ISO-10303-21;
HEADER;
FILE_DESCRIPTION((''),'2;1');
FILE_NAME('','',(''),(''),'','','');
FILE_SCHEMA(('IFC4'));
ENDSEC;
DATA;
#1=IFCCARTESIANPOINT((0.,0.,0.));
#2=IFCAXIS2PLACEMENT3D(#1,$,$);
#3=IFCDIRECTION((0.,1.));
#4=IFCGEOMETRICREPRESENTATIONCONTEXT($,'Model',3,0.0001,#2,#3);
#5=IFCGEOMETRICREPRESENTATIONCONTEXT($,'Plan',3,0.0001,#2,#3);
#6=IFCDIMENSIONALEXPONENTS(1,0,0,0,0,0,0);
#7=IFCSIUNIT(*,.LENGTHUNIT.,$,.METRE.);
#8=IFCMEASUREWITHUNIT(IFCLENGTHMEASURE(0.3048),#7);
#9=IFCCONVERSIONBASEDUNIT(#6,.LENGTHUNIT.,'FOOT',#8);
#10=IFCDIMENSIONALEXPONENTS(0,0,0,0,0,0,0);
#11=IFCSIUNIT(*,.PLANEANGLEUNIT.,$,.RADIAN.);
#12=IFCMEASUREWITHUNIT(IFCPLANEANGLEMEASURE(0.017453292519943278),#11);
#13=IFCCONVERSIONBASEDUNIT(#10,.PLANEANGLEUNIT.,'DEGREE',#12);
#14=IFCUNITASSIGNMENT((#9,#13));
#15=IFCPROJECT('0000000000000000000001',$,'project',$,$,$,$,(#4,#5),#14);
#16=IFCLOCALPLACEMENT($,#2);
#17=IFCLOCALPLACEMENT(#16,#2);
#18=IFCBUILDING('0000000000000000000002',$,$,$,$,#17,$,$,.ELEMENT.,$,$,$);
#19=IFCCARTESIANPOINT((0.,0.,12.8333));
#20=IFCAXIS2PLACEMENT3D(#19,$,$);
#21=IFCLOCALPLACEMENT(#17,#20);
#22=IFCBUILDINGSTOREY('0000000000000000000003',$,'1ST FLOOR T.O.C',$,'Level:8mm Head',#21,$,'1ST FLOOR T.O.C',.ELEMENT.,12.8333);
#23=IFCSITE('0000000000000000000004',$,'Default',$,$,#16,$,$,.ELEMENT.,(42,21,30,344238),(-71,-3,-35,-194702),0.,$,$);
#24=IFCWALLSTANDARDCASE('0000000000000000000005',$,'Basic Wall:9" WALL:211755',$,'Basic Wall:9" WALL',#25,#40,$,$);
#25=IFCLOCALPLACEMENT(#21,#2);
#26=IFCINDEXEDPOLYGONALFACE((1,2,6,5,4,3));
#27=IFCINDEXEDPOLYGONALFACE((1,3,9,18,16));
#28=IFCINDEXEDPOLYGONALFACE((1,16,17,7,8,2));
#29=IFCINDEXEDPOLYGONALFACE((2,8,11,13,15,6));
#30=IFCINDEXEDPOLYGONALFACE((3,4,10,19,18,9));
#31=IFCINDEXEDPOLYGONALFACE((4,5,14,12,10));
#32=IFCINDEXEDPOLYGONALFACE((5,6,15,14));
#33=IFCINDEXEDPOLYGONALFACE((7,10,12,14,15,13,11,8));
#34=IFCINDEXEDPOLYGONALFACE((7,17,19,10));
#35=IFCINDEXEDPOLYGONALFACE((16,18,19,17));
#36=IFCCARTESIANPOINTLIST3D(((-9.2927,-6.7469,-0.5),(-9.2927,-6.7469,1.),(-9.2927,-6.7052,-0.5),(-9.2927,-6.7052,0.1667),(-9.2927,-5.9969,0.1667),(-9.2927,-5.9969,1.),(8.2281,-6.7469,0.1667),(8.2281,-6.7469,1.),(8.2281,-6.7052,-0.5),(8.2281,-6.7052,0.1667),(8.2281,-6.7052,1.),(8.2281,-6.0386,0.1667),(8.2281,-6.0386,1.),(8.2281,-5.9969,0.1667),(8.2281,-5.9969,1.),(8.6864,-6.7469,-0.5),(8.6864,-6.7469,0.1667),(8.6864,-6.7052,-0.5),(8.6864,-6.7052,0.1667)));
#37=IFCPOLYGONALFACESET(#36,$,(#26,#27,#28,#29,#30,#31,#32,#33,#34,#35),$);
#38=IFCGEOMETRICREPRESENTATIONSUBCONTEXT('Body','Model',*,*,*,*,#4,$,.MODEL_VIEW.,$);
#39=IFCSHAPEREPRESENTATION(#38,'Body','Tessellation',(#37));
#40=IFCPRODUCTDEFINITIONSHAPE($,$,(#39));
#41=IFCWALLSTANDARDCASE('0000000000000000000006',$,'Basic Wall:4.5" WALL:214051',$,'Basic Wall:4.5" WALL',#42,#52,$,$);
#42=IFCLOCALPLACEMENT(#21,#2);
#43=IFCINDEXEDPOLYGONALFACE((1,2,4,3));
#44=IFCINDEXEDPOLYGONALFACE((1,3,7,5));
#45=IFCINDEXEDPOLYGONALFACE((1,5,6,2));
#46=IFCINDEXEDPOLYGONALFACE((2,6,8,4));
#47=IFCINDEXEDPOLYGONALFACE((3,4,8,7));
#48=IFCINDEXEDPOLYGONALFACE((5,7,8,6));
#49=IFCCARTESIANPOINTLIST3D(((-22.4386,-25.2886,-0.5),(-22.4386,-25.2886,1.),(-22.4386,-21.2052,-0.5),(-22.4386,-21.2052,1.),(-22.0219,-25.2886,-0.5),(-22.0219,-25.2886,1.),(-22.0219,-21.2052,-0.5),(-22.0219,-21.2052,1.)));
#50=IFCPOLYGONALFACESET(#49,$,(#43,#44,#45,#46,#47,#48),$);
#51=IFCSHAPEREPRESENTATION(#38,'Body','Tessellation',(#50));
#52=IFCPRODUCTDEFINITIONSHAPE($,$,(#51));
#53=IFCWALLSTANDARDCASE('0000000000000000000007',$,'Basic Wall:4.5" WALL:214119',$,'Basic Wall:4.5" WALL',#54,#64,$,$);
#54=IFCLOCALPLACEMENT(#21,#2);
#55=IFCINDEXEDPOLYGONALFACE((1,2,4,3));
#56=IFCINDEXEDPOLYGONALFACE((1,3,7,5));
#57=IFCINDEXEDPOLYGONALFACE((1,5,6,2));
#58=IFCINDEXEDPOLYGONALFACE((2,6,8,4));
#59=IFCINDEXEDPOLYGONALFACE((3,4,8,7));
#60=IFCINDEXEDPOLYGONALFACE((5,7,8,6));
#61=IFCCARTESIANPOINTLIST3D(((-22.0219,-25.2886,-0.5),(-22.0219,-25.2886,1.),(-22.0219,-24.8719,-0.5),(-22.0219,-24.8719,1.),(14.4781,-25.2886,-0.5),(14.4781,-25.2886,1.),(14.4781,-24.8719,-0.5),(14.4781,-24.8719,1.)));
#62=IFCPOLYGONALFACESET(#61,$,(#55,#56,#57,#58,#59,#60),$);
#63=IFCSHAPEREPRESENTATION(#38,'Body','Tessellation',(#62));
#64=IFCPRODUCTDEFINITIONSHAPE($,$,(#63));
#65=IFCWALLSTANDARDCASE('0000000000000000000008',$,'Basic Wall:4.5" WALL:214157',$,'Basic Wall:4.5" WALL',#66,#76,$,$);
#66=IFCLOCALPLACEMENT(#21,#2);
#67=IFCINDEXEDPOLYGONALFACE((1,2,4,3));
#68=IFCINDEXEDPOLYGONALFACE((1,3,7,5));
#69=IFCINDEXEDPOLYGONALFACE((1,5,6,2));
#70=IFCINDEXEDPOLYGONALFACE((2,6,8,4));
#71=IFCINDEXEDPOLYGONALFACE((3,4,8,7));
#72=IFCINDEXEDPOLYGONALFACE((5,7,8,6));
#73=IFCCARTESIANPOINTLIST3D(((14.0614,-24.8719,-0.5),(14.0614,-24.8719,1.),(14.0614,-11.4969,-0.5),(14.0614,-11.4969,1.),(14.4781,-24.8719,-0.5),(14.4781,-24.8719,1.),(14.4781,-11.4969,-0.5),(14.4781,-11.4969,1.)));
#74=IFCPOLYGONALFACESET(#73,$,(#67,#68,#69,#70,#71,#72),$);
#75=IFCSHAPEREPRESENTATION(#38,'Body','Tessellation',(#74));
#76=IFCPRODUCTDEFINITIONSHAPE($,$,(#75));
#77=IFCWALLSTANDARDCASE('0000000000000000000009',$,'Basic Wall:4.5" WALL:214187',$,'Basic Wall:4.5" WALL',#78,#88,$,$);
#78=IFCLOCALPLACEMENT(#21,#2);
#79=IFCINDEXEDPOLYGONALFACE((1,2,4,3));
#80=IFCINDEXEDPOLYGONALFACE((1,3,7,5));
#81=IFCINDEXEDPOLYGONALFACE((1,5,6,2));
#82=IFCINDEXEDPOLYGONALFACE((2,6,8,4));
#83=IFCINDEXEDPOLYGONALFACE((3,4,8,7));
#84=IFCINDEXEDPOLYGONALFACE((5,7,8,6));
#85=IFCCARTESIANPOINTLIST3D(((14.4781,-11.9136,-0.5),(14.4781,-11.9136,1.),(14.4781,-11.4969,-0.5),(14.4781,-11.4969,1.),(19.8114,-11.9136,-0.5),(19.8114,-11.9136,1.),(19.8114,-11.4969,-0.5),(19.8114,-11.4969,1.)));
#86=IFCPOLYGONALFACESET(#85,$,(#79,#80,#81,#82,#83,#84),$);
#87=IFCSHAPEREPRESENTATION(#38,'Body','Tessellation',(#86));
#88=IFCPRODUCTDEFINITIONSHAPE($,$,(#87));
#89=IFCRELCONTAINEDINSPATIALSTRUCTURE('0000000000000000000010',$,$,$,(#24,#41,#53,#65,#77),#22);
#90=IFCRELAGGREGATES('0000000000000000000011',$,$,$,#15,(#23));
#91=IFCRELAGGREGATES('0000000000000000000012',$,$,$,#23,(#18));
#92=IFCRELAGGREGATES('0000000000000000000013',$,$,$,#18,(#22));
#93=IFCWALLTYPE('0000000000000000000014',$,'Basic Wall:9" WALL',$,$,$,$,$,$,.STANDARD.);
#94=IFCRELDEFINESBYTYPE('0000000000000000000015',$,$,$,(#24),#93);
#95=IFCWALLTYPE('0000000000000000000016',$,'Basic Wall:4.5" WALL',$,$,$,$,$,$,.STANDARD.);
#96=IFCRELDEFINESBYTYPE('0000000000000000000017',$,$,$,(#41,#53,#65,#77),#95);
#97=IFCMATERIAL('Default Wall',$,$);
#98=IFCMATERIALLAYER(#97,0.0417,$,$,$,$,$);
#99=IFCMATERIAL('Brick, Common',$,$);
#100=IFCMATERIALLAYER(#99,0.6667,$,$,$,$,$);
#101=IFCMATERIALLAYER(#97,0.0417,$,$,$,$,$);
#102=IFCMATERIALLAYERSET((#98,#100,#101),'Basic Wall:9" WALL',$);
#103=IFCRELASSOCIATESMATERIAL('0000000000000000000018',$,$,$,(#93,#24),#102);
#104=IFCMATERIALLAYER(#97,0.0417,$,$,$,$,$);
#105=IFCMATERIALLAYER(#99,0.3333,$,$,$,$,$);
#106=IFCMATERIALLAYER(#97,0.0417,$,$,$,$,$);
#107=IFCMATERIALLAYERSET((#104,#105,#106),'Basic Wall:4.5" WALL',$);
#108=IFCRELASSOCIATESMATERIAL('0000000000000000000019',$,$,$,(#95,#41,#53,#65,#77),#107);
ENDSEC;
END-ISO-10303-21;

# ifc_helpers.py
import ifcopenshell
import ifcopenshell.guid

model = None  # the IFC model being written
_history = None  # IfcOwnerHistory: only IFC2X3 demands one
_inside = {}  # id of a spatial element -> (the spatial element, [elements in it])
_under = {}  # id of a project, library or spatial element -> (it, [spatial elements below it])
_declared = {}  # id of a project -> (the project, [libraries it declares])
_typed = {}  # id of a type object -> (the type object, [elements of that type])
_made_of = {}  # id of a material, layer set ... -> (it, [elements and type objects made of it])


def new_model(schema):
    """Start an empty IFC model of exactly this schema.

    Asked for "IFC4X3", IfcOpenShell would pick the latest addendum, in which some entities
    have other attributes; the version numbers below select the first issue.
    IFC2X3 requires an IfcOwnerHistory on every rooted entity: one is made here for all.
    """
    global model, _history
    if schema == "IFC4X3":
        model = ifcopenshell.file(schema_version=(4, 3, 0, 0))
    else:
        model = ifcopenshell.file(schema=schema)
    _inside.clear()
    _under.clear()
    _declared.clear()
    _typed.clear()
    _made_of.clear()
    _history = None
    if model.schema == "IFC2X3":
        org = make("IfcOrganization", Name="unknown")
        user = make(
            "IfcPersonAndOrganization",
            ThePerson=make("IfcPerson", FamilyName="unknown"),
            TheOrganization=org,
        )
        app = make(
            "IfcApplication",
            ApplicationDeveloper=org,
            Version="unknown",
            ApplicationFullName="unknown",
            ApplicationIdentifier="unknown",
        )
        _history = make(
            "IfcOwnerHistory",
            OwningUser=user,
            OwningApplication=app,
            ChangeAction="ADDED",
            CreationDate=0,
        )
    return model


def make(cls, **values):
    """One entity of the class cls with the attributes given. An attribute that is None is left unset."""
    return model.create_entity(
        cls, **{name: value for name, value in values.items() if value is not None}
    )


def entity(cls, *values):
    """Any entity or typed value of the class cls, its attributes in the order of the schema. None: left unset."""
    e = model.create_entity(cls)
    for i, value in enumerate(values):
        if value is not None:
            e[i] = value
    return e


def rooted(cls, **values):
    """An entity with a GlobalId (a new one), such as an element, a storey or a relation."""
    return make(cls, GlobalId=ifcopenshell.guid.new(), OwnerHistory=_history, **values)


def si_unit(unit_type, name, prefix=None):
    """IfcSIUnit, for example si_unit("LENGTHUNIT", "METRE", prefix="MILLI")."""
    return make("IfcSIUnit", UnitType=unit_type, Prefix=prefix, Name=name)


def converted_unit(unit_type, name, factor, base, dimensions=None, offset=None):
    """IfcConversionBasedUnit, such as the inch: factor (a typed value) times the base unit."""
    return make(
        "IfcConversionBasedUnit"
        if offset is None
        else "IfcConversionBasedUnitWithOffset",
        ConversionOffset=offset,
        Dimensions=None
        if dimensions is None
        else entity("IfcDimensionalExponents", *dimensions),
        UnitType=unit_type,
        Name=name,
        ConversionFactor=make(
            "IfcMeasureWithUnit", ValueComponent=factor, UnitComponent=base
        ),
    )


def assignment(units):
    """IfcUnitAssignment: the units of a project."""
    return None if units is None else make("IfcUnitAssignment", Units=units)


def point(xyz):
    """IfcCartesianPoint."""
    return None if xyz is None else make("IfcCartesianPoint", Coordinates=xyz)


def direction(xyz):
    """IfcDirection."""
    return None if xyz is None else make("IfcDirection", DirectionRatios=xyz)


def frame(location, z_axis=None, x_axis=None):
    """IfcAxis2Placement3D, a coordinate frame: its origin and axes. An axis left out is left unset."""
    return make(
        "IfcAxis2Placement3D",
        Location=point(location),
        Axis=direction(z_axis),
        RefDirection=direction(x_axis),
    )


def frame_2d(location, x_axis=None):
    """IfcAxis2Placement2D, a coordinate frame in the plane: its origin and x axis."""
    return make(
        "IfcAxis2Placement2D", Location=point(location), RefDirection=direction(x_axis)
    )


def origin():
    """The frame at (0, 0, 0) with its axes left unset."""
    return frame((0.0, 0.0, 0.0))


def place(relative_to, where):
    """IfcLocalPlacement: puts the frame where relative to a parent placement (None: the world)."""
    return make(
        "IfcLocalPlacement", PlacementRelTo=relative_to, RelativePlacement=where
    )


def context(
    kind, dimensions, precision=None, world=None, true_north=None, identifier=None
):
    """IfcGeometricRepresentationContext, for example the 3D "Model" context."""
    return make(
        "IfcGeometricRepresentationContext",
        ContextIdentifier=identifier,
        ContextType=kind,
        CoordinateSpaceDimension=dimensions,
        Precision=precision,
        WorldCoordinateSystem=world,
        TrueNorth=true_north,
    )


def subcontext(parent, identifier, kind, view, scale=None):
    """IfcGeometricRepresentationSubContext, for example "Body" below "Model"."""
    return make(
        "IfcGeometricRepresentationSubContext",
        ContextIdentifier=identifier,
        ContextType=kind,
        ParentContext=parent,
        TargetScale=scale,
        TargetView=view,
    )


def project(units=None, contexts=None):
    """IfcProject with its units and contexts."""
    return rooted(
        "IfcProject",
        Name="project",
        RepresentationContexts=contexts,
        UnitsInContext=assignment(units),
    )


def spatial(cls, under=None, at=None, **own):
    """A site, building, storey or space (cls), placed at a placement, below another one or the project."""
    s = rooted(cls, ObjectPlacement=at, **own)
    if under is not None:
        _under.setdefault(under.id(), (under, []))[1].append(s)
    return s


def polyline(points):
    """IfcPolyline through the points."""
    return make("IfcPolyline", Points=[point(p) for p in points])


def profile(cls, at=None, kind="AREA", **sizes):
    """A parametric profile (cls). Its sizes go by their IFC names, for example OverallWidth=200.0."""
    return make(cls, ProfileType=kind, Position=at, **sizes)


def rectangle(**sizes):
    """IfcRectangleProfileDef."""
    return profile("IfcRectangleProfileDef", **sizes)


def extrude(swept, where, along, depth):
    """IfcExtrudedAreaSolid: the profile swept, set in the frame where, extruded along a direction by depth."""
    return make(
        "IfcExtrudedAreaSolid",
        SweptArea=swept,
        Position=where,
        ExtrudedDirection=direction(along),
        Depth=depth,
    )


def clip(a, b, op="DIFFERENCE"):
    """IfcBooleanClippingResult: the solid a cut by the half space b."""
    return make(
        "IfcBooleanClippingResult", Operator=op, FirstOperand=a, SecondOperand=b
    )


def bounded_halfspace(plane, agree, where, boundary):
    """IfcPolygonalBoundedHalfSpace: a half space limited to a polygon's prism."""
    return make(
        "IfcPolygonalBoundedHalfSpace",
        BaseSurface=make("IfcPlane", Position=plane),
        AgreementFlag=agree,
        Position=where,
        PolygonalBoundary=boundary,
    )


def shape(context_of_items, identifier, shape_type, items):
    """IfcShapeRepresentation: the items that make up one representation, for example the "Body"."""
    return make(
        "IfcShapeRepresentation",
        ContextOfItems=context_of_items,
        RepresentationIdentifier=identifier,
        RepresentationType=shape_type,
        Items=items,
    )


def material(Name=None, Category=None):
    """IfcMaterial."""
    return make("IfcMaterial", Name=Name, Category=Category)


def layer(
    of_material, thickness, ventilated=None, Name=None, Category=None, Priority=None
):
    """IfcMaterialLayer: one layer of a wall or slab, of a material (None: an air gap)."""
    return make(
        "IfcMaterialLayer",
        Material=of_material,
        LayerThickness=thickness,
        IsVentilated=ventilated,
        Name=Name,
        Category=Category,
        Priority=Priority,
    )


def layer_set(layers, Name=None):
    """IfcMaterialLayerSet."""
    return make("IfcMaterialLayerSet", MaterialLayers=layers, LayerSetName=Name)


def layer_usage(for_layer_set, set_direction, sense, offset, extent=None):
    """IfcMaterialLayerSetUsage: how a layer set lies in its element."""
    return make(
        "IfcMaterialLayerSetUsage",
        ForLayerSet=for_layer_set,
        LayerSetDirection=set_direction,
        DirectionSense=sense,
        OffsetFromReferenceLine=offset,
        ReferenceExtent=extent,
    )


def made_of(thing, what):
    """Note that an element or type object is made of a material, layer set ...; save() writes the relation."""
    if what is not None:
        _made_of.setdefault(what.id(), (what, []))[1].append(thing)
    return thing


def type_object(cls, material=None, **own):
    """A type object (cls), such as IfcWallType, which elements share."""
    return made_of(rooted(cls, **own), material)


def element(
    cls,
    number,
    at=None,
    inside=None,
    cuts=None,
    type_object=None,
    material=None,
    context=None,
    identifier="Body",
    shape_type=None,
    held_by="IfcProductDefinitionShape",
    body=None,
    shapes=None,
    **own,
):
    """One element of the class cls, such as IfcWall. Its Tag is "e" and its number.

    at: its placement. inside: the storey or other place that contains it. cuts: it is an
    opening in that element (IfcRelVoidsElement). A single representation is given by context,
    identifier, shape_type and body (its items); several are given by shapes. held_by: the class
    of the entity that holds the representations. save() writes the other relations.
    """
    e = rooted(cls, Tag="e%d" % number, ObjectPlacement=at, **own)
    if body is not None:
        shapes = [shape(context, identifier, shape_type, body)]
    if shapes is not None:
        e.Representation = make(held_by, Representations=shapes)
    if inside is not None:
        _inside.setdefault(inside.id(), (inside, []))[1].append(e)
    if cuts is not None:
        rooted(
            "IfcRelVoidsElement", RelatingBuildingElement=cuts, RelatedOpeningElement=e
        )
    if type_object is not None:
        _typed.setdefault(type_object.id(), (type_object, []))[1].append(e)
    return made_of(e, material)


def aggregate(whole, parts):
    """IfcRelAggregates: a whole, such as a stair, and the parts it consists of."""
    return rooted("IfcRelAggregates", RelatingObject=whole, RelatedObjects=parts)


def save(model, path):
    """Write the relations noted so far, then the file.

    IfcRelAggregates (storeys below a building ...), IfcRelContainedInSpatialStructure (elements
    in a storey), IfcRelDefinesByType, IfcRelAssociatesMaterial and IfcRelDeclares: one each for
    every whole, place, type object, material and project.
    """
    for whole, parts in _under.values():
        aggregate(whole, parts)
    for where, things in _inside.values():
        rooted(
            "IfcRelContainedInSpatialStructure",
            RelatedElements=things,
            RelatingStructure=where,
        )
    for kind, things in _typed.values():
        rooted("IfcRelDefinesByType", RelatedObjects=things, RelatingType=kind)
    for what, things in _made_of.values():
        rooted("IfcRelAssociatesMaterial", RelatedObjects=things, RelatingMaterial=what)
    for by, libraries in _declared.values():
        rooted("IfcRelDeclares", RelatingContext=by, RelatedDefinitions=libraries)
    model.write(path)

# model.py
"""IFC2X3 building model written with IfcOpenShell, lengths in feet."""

from ifc_helpers import new_model, entity, si_unit, converted_unit, direction, frame, frame_2d, origin, place, context, subcontext, project, spatial, polyline, rectangle, extrude, clip, bounded_halfspace, material, layer, layer_set, layer_usage, type_object, element, save


model = new_model("IFC2X3")

# Units and contexts
model_context = context("Model", 3, precision=0.0001, world=origin(), true_north=direction((0.0, 1.0)))
plan_context = context("Plan", 3, precision=0.0001, world=origin(), true_north=direction((0.0, 1.0)))
body_context = subcontext(model_context, "Body", "Model", "MODEL_VIEW")
ifc_project = project(units=[converted_unit("LENGTHUNIT", "FOOT", entity("IfcLengthMeasure", 0.3048), si_unit("LENGTHUNIT", "METRE"), dimensions=[1, 0, 0, 0, 0, 0, 0]), converted_unit("PLANEANGLEUNIT", "DEGREE", entity("IfcPlaneAngleMeasure", 0.017453292519943278), si_unit("PLANEANGLEUNIT", "RADIAN"), dimensions=[0, 0, 0, 0, 0, 0, 0])], contexts=[model_context, plan_context])

# Site, building, storey
site_placement = place(None, origin())
site = spatial("IfcSite", under=ifc_project, at=site_placement, Name="Default", CompositionType="ELEMENT", RefLatitude=(42, 21, 30, 344238), RefLongitude=(-71, -3, -35, -194702), RefElevation=0.0)
building_placement = place(site_placement, origin())
building = spatial("IfcBuilding", under=site, at=building_placement, CompositionType="ELEMENT")
storey_placement = place(building_placement, frame((0.0, 0.0, 12.8333)))
storey = spatial("IfcBuildingStorey", under=building, at=storey_placement, Name="1ST FLOOR T.O.C", ObjectType="Level:8mm Head", LongName="1ST FLOOR T.O.C", CompositionType="ELEMENT", Elevation=12.8333)

# Walls
ifc_material_1 = material(Name="Default Wall")
ifc_layer_1 = layer(ifc_material_1, 0.0417)
ifc_material_2 = material(Name="Brick, Common")
ifc_layer_2 = layer(ifc_material_2, 0.6667)
ifc_layer_3 = layer(ifc_material_1, 0.0417)
ifc_layer_set_1 = layer_set([ifc_layer_1, ifc_layer_2, ifc_layer_3], Name="Basic Wall:9\" WALL")
ifc_layer_usage_1 = layer_usage(ifc_layer_set_1, "AXIS2", "NEGATIVE", 0.375)
wall_type_1 = type_object("IfcWallType", Name="Basic Wall:9\" WALL", PredefinedType="STANDARD", material=ifc_layer_set_1)
wall_1_placement = place(storey_placement, frame((8.6864, -6.3719, -0.5), z_axis=(0.0, 0.0, 1.0), x_axis=(-1.0, 0.0, 0.0)))
element("IfcWallStandardCase", 1, at=wall_1_placement, inside=storey, type_object=wall_type_1, material=ifc_layer_usage_1, Name="Basic Wall:9\" WALL:211755", ObjectType="Basic Wall:9\" WALL", context=body_context, shape_type="Clipping", body=[
    clip(clip(clip(clip(extrude(rectangle(XDim=17.9792, YDim=0.75, at=frame_2d((8.9896, 0.0), x_axis=(-1.0, 0.0))), origin(), (0.0, 0.0, 1.0), 1.5), bounded_halfspace(frame((17.9792, -0.375, 0.6667), z_axis=(0.0, 0.0, 1.0), x_axis=(0.0, -1.0, 0.0)), True, frame((17.9792, -0.375, 0.6667), z_axis=(0.0, 0.0, 1.0), x_axis=(0.0, -1.0, 0.0)), polyline([(0.0, 0.0), (-0.4167, 0.0), (-0.7083, 0.0), (-0.7083, -17.5208), (-0.0417, -17.5208), (-0.0417, -17.9792), (0.0, -17.9792), (0.0, 0.0)]))), bounded_halfspace(frame((17.9792, 0.3333, 0.0), z_axis=(0.0, 1.0, 0.0), x_axis=(0.0, 0.0, 1.0)), True, frame((17.9792, 0.3333, 0.0), z_axis=(0.0, 1.0, 0.0), x_axis=(0.0, 0.0, 1.0)), polyline([(0.0, 0.0), (0.0, -17.9792), (0.6667, -17.9792), (1.5, -17.9792), (1.5, -17.5208), (0.6667, -17.5208), (0.6667, 0.0), (0.0, 0.0)]))), bounded_halfspace(frame((0.4583, 0.3333, 1.5), z_axis=(1.0, 0.0, 0.0), x_axis=(0.0, 0.0, -1.0)), True, frame((0.4583, 0.3333, 1.5), z_axis=(1.0, 0.0, 0.0), x_axis=(0.0, 0.0, -1.0)), polyline([(0.0, 0.0), (0.0, -0.6667), (0.8333, -0.6667), (0.8333, 0.0), (0.0, 0.0)]))), bounded_halfspace(frame((0.4583, -0.3333, 1.5), z_axis=(0.0, -1.0, 0.0), x_axis=(0.0, 0.0, -1.0)), True, frame((0.4583, -0.3333, 1.5), z_axis=(0.0, -1.0, 0.0), x_axis=(0.0, 0.0, -1.0)), polyline([(0.0, 0.0), (0.0, -0.4583), (0.8333, -0.4583), (0.8333, 0.0), (0.0, 0.0)]))),
])
ifc_layer_4 = layer(ifc_material_1, 0.0417)
ifc_layer_5 = layer(ifc_material_2, 0.3333)
ifc_layer_6 = layer(ifc_material_1, 0.0417)
ifc_layer_set_2 = layer_set([ifc_layer_4, ifc_layer_5, ifc_layer_6], Name="Basic Wall:4.5\" WALL")
ifc_layer_usage_2 = layer_usage(ifc_layer_set_2, "AXIS2", "NEGATIVE", 0.2083)
wall_type_2 = type_object("IfcWallType", Name="Basic Wall:4.5\" WALL", PredefinedType="STANDARD", material=ifc_layer_set_2)
wall_2_placement = place(storey_placement, frame((-22.2302, -21.2052, -0.5), z_axis=(0.0, 0.0, 1.0), x_axis=(0.0, -1.0, 0.0)))
element("IfcWallStandardCase", 2, at=wall_2_placement, inside=storey, type_object=wall_type_2, material=ifc_layer_usage_2, Name="Basic Wall:4.5\" WALL:214051", ObjectType="Basic Wall:4.5\" WALL", context=body_context, shape_type="SweptSolid", body=[
    extrude(rectangle(XDim=4.0833, YDim=0.4167, at=frame_2d((2.0417, 0.0), x_axis=(-1.0, 0.0))), origin(), (0.0, 0.0, 1.0), 1.5),
])
ifc_layer_usage_3 = layer_usage(ifc_layer_set_2, "AXIS2", "NEGATIVE", 0.2083)
wall_3_placement = place(storey_placement, frame((-22.0219, -25.0802, -0.5)))
element("IfcWallStandardCase", 3, at=wall_3_placement, inside=storey, type_object=wall_type_2, material=ifc_layer_usage_3, Name="Basic Wall:4.5\" WALL:214119", ObjectType="Basic Wall:4.5\" WALL", context=body_context, shape_type="SweptSolid", body=[
    extrude(rectangle(XDim=36.5, YDim=0.4167, at=frame_2d((18.25, 0.0), x_axis=(-1.0, 0.0))), origin(), (0.0, 0.0, 1.0), 1.5),
])
ifc_layer_usage_4 = layer_usage(ifc_layer_set_2, "AXIS2", "NEGATIVE", 0.2083)
wall_4_placement = place(storey_placement, frame((14.2698, -24.8719, -0.5), z_axis=(0.0, 0.0, 1.0), x_axis=(0.0, 1.0, 0.0)))
element("IfcWallStandardCase", 4, at=wall_4_placement, inside=storey, type_object=wall_type_2, material=ifc_layer_usage_4, Name="Basic Wall:4.5\" WALL:214157", ObjectType="Basic Wall:4.5\" WALL", context=body_context, shape_type="SweptSolid", body=[
    extrude(rectangle(XDim=13.375, YDim=0.4167, at=frame_2d((6.6875, 0.0), x_axis=(-1.0, 0.0))), origin(), (0.0, 0.0, 1.0), 1.5),
])
ifc_layer_usage_5 = layer_usage(ifc_layer_set_2, "AXIS2", "NEGATIVE", 0.2083)
wall_5_placement = place(storey_placement, frame((14.4781, -11.7052, -0.5)))
element("IfcWallStandardCase", 5, at=wall_5_placement, inside=storey, type_object=wall_type_2, material=ifc_layer_usage_5, Name="Basic Wall:4.5\" WALL:214187", ObjectType="Basic Wall:4.5\" WALL", context=body_context, shape_type="SweptSolid", body=[
    extrude(rectangle(XDim=5.3333, YDim=0.4167, at=frame_2d((2.6667, 0.0), x_axis=(-1.0, 0.0))), origin(), (0.0, 0.0, 1.0), 1.5),
])

save(model, "model.ifc")
